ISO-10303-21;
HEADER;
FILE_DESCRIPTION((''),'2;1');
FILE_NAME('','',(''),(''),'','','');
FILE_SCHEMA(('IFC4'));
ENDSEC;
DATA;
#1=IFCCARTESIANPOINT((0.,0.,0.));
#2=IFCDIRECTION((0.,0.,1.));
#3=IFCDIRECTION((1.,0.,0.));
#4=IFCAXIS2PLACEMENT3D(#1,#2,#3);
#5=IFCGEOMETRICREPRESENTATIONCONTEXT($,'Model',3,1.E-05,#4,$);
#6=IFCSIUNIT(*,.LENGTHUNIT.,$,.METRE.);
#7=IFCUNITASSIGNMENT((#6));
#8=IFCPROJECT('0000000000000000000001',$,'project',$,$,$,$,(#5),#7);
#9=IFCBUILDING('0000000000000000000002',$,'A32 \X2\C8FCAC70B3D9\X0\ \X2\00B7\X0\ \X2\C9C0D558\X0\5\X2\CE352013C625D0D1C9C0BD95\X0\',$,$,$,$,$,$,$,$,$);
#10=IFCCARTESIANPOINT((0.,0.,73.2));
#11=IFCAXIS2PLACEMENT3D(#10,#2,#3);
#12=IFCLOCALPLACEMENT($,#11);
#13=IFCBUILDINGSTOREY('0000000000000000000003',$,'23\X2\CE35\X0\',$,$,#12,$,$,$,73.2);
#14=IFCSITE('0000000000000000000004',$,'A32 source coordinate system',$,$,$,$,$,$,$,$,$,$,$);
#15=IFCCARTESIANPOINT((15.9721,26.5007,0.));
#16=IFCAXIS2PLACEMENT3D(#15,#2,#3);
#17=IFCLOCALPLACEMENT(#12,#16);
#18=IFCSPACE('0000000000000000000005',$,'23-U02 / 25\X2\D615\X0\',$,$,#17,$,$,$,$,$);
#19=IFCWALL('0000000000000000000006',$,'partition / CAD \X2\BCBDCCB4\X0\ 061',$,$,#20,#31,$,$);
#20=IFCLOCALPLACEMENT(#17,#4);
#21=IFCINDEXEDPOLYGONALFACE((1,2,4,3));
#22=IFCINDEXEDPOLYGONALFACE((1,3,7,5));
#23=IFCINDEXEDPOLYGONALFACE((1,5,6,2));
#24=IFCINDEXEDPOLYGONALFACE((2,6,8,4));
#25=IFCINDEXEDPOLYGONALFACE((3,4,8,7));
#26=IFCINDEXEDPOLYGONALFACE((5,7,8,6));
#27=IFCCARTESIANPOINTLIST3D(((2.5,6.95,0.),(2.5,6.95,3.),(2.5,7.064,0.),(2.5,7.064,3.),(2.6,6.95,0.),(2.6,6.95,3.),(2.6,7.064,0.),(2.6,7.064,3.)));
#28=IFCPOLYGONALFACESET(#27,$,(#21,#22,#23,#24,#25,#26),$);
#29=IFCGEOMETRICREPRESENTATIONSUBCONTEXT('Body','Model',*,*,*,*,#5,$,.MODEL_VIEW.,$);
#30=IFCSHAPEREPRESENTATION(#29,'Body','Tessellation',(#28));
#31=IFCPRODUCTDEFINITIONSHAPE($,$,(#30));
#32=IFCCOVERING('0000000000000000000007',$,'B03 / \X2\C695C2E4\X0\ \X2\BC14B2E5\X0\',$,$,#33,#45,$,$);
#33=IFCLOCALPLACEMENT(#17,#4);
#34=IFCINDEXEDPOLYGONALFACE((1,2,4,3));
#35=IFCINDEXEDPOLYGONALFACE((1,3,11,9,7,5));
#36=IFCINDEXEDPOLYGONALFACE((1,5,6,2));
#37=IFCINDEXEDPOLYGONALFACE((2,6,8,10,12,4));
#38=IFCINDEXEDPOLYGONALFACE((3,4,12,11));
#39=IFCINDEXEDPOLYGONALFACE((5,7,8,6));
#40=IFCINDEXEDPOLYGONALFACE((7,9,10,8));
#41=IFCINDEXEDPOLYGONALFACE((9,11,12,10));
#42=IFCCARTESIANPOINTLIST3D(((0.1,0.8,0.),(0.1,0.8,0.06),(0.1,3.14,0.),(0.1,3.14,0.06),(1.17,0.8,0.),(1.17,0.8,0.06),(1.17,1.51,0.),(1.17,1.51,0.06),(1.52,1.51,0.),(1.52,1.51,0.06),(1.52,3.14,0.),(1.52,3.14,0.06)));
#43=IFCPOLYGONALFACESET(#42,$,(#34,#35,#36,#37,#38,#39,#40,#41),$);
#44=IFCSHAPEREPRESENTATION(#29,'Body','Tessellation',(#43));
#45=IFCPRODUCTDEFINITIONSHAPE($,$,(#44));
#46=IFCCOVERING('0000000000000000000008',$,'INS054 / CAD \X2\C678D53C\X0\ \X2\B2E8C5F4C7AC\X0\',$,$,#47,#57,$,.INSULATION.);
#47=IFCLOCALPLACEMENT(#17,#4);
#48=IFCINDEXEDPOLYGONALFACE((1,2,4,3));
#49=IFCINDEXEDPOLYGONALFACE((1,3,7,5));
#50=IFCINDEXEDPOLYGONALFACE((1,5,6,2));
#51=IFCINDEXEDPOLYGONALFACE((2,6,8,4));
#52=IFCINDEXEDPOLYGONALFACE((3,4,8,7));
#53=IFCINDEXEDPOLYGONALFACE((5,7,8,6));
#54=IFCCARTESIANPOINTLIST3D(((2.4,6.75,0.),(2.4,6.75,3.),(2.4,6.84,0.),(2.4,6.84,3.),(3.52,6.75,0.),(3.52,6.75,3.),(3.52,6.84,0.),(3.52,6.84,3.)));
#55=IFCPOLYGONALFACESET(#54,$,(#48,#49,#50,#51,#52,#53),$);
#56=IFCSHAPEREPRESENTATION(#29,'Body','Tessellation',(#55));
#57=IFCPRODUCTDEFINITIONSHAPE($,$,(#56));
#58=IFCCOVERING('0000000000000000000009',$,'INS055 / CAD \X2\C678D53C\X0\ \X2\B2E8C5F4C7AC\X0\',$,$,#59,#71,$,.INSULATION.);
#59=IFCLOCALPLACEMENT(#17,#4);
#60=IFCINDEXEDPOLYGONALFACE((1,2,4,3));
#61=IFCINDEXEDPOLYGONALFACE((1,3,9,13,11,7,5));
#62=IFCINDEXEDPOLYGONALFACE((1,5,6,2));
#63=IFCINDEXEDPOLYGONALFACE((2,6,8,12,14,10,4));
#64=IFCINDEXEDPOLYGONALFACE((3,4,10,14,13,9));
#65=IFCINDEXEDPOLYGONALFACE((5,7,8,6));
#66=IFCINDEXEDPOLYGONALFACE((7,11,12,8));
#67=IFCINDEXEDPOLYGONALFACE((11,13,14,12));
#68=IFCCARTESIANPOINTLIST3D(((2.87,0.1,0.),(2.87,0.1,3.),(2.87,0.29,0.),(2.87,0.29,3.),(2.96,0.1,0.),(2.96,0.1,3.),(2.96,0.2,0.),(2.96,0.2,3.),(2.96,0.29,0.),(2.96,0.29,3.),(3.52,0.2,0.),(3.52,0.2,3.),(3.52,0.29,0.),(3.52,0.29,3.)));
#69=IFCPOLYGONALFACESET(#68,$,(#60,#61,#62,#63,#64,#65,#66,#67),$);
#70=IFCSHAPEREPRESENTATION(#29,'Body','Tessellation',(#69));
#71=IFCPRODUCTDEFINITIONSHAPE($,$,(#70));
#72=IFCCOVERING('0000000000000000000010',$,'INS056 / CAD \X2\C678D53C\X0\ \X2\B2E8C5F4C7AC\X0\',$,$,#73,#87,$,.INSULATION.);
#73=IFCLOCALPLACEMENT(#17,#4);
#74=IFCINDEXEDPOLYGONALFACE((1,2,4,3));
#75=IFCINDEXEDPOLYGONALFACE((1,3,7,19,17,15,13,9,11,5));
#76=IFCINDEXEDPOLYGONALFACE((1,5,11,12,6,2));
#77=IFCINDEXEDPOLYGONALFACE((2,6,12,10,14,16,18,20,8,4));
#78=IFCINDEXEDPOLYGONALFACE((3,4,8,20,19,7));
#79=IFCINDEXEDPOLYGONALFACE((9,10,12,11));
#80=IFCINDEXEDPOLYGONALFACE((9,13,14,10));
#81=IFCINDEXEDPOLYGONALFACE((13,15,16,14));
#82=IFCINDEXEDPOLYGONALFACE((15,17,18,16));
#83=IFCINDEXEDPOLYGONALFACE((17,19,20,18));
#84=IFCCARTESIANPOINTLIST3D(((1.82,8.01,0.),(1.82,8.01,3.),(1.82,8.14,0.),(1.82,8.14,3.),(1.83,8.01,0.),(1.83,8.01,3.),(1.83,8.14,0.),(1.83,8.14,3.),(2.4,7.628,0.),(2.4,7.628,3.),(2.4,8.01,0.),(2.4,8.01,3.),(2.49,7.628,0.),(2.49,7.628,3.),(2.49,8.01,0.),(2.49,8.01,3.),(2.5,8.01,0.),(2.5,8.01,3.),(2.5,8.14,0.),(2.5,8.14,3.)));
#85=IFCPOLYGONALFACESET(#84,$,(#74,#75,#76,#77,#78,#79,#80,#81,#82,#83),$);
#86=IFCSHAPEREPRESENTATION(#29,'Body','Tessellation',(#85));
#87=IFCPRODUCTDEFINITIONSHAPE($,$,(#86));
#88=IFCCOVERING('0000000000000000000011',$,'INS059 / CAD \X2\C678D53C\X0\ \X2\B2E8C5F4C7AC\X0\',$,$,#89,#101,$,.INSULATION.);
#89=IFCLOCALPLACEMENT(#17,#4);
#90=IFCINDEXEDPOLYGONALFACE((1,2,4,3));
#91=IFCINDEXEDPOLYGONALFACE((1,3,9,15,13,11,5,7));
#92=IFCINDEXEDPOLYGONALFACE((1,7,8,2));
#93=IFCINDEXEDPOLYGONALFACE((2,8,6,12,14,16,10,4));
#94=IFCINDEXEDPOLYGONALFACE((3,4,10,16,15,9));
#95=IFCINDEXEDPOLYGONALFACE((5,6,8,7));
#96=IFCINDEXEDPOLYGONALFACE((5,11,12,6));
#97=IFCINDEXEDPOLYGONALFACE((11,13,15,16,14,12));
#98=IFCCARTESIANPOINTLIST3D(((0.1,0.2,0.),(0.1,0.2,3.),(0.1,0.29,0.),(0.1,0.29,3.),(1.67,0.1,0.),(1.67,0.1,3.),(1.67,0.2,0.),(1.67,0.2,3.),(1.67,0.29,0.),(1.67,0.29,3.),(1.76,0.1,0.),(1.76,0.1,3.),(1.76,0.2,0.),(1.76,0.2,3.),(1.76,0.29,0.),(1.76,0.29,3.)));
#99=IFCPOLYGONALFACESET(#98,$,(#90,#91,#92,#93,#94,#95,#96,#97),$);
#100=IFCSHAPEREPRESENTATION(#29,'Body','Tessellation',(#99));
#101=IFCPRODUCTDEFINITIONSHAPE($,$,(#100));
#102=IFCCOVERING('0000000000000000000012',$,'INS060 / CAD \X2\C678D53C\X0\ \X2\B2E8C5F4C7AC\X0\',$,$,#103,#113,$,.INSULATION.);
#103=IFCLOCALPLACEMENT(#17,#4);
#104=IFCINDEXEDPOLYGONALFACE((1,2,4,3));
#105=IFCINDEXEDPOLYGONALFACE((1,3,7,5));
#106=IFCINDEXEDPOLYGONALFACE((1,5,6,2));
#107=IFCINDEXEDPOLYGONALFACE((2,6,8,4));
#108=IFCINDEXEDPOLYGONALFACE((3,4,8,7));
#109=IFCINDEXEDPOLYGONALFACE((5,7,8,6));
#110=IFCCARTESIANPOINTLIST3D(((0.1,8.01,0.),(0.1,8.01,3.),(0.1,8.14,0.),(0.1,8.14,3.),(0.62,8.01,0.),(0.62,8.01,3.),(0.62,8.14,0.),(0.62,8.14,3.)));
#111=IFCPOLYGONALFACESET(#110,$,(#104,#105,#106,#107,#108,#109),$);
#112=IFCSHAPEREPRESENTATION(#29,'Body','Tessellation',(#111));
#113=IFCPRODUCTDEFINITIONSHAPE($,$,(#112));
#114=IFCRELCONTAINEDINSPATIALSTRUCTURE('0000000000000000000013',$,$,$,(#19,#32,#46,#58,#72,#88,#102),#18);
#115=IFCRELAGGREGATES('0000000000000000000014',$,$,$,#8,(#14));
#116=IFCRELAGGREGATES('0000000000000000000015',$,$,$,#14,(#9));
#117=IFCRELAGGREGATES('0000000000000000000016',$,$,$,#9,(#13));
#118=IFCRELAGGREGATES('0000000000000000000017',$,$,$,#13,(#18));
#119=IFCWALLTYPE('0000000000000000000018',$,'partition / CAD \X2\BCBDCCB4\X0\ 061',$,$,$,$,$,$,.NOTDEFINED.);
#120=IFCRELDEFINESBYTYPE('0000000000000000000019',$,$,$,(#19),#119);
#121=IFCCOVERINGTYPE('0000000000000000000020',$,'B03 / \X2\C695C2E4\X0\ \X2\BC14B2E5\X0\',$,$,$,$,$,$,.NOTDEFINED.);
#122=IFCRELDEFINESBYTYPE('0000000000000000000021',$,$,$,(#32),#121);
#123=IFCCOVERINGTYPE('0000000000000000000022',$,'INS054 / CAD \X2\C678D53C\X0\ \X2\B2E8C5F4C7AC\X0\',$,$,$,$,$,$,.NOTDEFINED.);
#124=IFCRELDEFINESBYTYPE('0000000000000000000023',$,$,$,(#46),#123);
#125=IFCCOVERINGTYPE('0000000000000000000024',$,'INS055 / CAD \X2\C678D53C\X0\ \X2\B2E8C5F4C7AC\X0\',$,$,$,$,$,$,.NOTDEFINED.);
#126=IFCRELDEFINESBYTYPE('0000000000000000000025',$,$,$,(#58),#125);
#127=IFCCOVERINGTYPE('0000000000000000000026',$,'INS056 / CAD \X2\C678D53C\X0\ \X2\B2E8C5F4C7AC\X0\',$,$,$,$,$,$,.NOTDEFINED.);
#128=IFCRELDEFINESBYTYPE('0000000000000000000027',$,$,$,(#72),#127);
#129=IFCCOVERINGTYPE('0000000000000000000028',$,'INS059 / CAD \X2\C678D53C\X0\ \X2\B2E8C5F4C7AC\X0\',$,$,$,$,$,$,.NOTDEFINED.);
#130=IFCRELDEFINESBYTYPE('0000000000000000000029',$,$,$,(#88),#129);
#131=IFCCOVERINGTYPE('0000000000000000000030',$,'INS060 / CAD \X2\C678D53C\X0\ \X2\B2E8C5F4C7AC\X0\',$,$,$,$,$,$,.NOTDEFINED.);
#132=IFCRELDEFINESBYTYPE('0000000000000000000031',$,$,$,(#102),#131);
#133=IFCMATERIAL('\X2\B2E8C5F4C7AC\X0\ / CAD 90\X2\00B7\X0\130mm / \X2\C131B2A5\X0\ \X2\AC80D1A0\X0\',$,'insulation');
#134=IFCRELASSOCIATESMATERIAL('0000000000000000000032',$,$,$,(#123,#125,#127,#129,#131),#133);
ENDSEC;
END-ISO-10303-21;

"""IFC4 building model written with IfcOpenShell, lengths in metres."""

from ifc_helpers import new_model, si_unit, frame, origin, origin_with_axes, place, context, subcontext, project, spatial, polyline, outline, extrude, source, transform, mapped, material, type_object, type_shapes, element, save


model = new_model("IFC4")

# Units and contexts
model_context = context("Model", 3, precision=1e-05, world=origin_with_axes())
body_context = subcontext(model_context, "Body", "Model", "MODEL_VIEW")
ifc_project = project(units=[si_unit("LENGTHUNIT", "METRE")], contexts=[model_context])

# Site, building, storey, space
storey_placement = place(None, frame((0.0, 0.0, 73.2), z_axis=(0.0, 0.0, 1.0), x_axis=(1.0, 0.0, 0.0)))
space_placement = place(storey_placement, frame((15.9721, 26.5007, 0.0), z_axis=(0.0, 0.0, 1.0), x_axis=(1.0, 0.0, 0.0)))
site = spatial("IfcSite", under=ifc_project, Name="A32 source coordinate system")
building = spatial("IfcBuilding", under=site, Name="A32 주거동 · 지하5층–옥탑지붕")
storey = spatial("IfcBuildingStorey", under=building, at=storey_placement, Name="23층", Elevation=73.2)
space = spatial("IfcSpace", under=storey, at=space_placement, Name="23-U02 / 25형")

# Wall
wall_type_1 = type_object("IfcWallType", Name="partition / CAD 벽체 061", PredefinedType="NOTDEFINED")
shared_shape_1 = source(origin(), body_context, "Body", "SweptSolid", [
    extrude(outline(polyline([(2.6, 7.064), (2.6, 6.95), (2.5, 6.95), (2.5, 7.064), (2.6, 7.064)])), origin(), (0.0, 0.0, 1.0), 3.0),
])
type_shapes(wall_type_1, [shared_shape_1])
wall_1_placement = place(space_placement, origin_with_axes())
element("IfcWall", 1, at=wall_1_placement, inside=space, type_object=wall_type_1, Name="partition / CAD 벽체 061", context=body_context, shape_type="MappedRepresentation", body=[
    mapped(shared_shape_1, transform((0.0, 0.0, 0.0), scale=1.0)),
])

# Coverings
covering_type_1 = type_object("IfcCoveringType", Name="B03 / 욕실 바닥", PredefinedType="NOTDEFINED")
shared_shape_2 = source(origin(), body_context, "Body", "SweptSolid", [
    extrude(outline(polyline([(1.17, 1.51), (1.17, 0.8), (0.1, 0.8), (0.1, 3.14), (1.52, 3.14), (1.52, 1.51), (1.17, 1.51)])), origin(), (0.0, 0.0, 1.0), 0.06),
])
type_shapes(covering_type_1, [shared_shape_2])
covering_1_placement = place(space_placement, origin_with_axes())
element("IfcCovering", 2, at=covering_1_placement, inside=space, type_object=covering_type_1, Name="B03 / 욕실 바닥", context=body_context, shape_type="MappedRepresentation", body=[
    mapped(shared_shape_2, transform((0.0, 0.0, 0.0), scale=1.0)),
])
ifc_material = material(Name="단열재 / CAD 90·130mm / 성능 검토", Category="insulation")
covering_type_2 = type_object("IfcCoveringType", Name="INS054 / CAD 외피 단열재", PredefinedType="NOTDEFINED", material=ifc_material)
shared_shape_3 = source(origin(), body_context, "Body", "SweptSolid", [
    extrude(outline(polyline([(2.4, 6.84), (3.52, 6.84), (3.52, 6.75), (2.4, 6.75), (2.4, 6.84)])), origin(), (0.0, 0.0, 1.0), 3.0),
])
type_shapes(covering_type_2, [shared_shape_3])
covering_2_placement = place(space_placement, origin_with_axes())
element("IfcCovering", 3, at=covering_2_placement, inside=space, type_object=covering_type_2, Name="INS054 / CAD 외피 단열재", PredefinedType="INSULATION", context=body_context, shape_type="MappedRepresentation", body=[
    mapped(shared_shape_3, transform((0.0, 0.0, 0.0), scale=1.0)),
])
covering_type_3 = type_object("IfcCoveringType", Name="INS055 / CAD 외피 단열재", PredefinedType="NOTDEFINED", material=ifc_material)
shared_shape_4 = source(origin(), body_context, "Body", "SweptSolid", [
    extrude(outline(polyline([(2.87, 0.29), (2.96, 0.29), (3.52, 0.29), (3.52, 0.2), (2.96, 0.2), (2.96, 0.1), (2.87, 0.1), (2.87, 0.29)])), origin(), (0.0, 0.0, 1.0), 3.0),
])
type_shapes(covering_type_3, [shared_shape_4])
covering_3_placement = place(space_placement, origin_with_axes())
element("IfcCovering", 4, at=covering_3_placement, inside=space, type_object=covering_type_3, Name="INS055 / CAD 외피 단열재", PredefinedType="INSULATION", context=body_context, shape_type="MappedRepresentation", body=[
    mapped(shared_shape_4, transform((0.0, 0.0, 0.0), scale=1.0)),
])
covering_type_4 = type_object("IfcCoveringType", Name="INS056 / CAD 외피 단열재", PredefinedType="NOTDEFINED", material=ifc_material)
shared_shape_5 = source(origin(), body_context, "Body", "SweptSolid", [
    extrude(outline(polyline([(2.49, 7.628), (2.4, 7.628), (2.4, 8.01), (1.83, 8.01), (1.82, 8.01), (1.82, 8.14), (1.83, 8.14), (2.5, 8.14), (2.5, 8.01), (2.49, 8.01), (2.49, 7.628)])), origin(), (0.0, 0.0, 1.0), 3.0),
])
type_shapes(covering_type_4, [shared_shape_5])
covering_4_placement = place(space_placement, origin_with_axes())
element("IfcCovering", 5, at=covering_4_placement, inside=space, type_object=covering_type_4, Name="INS056 / CAD 외피 단열재", PredefinedType="INSULATION", context=body_context, shape_type="MappedRepresentation", body=[
    mapped(shared_shape_5, transform((0.0, 0.0, 0.0), scale=1.0)),
])
covering_type_5 = type_object("IfcCoveringType", Name="INS059 / CAD 외피 단열재", PredefinedType="NOTDEFINED", material=ifc_material)
shared_shape_6 = source(origin(), body_context, "Body", "SweptSolid", [
    extrude(outline(polyline([(1.76, 0.1), (1.67, 0.1), (1.67, 0.2), (0.1, 0.2), (0.1, 0.29), (1.67, 0.29), (1.76, 0.29), (1.76, 0.2), (1.76, 0.1)])), origin(), (0.0, 0.0, 1.0), 3.0),
])
type_shapes(covering_type_5, [shared_shape_6])
covering_5_placement = place(space_placement, origin_with_axes())
element("IfcCovering", 6, at=covering_5_placement, inside=space, type_object=covering_type_5, Name="INS059 / CAD 외피 단열재", PredefinedType="INSULATION", context=body_context, shape_type="MappedRepresentation", body=[
    mapped(shared_shape_6, transform((0.0, 0.0, 0.0), scale=1.0)),
])
covering_type_6 = type_object("IfcCoveringType", Name="INS060 / CAD 외피 단열재", PredefinedType="NOTDEFINED", material=ifc_material)
shared_shape_7 = source(origin(), body_context, "Body", "SweptSolid", [
    extrude(outline(polyline([(0.1, 8.01), (0.1, 8.14), (0.62, 8.14), (0.62, 8.01), (0.1, 8.01)])), origin(), (0.0, 0.0, 1.0), 3.0),
])
type_shapes(covering_type_6, [shared_shape_7])
covering_6_placement = place(space_placement, origin_with_axes())
element("IfcCovering", 7, at=covering_6_placement, inside=space, type_object=covering_type_6, Name="INS060 / CAD 외피 단열재", PredefinedType="INSULATION", context=body_context, shape_type="MappedRepresentation", body=[
    mapped(shared_shape_7, transform((0.0, 0.0, 0.0), scale=1.0)),
])

save(model, "model.ifc")
